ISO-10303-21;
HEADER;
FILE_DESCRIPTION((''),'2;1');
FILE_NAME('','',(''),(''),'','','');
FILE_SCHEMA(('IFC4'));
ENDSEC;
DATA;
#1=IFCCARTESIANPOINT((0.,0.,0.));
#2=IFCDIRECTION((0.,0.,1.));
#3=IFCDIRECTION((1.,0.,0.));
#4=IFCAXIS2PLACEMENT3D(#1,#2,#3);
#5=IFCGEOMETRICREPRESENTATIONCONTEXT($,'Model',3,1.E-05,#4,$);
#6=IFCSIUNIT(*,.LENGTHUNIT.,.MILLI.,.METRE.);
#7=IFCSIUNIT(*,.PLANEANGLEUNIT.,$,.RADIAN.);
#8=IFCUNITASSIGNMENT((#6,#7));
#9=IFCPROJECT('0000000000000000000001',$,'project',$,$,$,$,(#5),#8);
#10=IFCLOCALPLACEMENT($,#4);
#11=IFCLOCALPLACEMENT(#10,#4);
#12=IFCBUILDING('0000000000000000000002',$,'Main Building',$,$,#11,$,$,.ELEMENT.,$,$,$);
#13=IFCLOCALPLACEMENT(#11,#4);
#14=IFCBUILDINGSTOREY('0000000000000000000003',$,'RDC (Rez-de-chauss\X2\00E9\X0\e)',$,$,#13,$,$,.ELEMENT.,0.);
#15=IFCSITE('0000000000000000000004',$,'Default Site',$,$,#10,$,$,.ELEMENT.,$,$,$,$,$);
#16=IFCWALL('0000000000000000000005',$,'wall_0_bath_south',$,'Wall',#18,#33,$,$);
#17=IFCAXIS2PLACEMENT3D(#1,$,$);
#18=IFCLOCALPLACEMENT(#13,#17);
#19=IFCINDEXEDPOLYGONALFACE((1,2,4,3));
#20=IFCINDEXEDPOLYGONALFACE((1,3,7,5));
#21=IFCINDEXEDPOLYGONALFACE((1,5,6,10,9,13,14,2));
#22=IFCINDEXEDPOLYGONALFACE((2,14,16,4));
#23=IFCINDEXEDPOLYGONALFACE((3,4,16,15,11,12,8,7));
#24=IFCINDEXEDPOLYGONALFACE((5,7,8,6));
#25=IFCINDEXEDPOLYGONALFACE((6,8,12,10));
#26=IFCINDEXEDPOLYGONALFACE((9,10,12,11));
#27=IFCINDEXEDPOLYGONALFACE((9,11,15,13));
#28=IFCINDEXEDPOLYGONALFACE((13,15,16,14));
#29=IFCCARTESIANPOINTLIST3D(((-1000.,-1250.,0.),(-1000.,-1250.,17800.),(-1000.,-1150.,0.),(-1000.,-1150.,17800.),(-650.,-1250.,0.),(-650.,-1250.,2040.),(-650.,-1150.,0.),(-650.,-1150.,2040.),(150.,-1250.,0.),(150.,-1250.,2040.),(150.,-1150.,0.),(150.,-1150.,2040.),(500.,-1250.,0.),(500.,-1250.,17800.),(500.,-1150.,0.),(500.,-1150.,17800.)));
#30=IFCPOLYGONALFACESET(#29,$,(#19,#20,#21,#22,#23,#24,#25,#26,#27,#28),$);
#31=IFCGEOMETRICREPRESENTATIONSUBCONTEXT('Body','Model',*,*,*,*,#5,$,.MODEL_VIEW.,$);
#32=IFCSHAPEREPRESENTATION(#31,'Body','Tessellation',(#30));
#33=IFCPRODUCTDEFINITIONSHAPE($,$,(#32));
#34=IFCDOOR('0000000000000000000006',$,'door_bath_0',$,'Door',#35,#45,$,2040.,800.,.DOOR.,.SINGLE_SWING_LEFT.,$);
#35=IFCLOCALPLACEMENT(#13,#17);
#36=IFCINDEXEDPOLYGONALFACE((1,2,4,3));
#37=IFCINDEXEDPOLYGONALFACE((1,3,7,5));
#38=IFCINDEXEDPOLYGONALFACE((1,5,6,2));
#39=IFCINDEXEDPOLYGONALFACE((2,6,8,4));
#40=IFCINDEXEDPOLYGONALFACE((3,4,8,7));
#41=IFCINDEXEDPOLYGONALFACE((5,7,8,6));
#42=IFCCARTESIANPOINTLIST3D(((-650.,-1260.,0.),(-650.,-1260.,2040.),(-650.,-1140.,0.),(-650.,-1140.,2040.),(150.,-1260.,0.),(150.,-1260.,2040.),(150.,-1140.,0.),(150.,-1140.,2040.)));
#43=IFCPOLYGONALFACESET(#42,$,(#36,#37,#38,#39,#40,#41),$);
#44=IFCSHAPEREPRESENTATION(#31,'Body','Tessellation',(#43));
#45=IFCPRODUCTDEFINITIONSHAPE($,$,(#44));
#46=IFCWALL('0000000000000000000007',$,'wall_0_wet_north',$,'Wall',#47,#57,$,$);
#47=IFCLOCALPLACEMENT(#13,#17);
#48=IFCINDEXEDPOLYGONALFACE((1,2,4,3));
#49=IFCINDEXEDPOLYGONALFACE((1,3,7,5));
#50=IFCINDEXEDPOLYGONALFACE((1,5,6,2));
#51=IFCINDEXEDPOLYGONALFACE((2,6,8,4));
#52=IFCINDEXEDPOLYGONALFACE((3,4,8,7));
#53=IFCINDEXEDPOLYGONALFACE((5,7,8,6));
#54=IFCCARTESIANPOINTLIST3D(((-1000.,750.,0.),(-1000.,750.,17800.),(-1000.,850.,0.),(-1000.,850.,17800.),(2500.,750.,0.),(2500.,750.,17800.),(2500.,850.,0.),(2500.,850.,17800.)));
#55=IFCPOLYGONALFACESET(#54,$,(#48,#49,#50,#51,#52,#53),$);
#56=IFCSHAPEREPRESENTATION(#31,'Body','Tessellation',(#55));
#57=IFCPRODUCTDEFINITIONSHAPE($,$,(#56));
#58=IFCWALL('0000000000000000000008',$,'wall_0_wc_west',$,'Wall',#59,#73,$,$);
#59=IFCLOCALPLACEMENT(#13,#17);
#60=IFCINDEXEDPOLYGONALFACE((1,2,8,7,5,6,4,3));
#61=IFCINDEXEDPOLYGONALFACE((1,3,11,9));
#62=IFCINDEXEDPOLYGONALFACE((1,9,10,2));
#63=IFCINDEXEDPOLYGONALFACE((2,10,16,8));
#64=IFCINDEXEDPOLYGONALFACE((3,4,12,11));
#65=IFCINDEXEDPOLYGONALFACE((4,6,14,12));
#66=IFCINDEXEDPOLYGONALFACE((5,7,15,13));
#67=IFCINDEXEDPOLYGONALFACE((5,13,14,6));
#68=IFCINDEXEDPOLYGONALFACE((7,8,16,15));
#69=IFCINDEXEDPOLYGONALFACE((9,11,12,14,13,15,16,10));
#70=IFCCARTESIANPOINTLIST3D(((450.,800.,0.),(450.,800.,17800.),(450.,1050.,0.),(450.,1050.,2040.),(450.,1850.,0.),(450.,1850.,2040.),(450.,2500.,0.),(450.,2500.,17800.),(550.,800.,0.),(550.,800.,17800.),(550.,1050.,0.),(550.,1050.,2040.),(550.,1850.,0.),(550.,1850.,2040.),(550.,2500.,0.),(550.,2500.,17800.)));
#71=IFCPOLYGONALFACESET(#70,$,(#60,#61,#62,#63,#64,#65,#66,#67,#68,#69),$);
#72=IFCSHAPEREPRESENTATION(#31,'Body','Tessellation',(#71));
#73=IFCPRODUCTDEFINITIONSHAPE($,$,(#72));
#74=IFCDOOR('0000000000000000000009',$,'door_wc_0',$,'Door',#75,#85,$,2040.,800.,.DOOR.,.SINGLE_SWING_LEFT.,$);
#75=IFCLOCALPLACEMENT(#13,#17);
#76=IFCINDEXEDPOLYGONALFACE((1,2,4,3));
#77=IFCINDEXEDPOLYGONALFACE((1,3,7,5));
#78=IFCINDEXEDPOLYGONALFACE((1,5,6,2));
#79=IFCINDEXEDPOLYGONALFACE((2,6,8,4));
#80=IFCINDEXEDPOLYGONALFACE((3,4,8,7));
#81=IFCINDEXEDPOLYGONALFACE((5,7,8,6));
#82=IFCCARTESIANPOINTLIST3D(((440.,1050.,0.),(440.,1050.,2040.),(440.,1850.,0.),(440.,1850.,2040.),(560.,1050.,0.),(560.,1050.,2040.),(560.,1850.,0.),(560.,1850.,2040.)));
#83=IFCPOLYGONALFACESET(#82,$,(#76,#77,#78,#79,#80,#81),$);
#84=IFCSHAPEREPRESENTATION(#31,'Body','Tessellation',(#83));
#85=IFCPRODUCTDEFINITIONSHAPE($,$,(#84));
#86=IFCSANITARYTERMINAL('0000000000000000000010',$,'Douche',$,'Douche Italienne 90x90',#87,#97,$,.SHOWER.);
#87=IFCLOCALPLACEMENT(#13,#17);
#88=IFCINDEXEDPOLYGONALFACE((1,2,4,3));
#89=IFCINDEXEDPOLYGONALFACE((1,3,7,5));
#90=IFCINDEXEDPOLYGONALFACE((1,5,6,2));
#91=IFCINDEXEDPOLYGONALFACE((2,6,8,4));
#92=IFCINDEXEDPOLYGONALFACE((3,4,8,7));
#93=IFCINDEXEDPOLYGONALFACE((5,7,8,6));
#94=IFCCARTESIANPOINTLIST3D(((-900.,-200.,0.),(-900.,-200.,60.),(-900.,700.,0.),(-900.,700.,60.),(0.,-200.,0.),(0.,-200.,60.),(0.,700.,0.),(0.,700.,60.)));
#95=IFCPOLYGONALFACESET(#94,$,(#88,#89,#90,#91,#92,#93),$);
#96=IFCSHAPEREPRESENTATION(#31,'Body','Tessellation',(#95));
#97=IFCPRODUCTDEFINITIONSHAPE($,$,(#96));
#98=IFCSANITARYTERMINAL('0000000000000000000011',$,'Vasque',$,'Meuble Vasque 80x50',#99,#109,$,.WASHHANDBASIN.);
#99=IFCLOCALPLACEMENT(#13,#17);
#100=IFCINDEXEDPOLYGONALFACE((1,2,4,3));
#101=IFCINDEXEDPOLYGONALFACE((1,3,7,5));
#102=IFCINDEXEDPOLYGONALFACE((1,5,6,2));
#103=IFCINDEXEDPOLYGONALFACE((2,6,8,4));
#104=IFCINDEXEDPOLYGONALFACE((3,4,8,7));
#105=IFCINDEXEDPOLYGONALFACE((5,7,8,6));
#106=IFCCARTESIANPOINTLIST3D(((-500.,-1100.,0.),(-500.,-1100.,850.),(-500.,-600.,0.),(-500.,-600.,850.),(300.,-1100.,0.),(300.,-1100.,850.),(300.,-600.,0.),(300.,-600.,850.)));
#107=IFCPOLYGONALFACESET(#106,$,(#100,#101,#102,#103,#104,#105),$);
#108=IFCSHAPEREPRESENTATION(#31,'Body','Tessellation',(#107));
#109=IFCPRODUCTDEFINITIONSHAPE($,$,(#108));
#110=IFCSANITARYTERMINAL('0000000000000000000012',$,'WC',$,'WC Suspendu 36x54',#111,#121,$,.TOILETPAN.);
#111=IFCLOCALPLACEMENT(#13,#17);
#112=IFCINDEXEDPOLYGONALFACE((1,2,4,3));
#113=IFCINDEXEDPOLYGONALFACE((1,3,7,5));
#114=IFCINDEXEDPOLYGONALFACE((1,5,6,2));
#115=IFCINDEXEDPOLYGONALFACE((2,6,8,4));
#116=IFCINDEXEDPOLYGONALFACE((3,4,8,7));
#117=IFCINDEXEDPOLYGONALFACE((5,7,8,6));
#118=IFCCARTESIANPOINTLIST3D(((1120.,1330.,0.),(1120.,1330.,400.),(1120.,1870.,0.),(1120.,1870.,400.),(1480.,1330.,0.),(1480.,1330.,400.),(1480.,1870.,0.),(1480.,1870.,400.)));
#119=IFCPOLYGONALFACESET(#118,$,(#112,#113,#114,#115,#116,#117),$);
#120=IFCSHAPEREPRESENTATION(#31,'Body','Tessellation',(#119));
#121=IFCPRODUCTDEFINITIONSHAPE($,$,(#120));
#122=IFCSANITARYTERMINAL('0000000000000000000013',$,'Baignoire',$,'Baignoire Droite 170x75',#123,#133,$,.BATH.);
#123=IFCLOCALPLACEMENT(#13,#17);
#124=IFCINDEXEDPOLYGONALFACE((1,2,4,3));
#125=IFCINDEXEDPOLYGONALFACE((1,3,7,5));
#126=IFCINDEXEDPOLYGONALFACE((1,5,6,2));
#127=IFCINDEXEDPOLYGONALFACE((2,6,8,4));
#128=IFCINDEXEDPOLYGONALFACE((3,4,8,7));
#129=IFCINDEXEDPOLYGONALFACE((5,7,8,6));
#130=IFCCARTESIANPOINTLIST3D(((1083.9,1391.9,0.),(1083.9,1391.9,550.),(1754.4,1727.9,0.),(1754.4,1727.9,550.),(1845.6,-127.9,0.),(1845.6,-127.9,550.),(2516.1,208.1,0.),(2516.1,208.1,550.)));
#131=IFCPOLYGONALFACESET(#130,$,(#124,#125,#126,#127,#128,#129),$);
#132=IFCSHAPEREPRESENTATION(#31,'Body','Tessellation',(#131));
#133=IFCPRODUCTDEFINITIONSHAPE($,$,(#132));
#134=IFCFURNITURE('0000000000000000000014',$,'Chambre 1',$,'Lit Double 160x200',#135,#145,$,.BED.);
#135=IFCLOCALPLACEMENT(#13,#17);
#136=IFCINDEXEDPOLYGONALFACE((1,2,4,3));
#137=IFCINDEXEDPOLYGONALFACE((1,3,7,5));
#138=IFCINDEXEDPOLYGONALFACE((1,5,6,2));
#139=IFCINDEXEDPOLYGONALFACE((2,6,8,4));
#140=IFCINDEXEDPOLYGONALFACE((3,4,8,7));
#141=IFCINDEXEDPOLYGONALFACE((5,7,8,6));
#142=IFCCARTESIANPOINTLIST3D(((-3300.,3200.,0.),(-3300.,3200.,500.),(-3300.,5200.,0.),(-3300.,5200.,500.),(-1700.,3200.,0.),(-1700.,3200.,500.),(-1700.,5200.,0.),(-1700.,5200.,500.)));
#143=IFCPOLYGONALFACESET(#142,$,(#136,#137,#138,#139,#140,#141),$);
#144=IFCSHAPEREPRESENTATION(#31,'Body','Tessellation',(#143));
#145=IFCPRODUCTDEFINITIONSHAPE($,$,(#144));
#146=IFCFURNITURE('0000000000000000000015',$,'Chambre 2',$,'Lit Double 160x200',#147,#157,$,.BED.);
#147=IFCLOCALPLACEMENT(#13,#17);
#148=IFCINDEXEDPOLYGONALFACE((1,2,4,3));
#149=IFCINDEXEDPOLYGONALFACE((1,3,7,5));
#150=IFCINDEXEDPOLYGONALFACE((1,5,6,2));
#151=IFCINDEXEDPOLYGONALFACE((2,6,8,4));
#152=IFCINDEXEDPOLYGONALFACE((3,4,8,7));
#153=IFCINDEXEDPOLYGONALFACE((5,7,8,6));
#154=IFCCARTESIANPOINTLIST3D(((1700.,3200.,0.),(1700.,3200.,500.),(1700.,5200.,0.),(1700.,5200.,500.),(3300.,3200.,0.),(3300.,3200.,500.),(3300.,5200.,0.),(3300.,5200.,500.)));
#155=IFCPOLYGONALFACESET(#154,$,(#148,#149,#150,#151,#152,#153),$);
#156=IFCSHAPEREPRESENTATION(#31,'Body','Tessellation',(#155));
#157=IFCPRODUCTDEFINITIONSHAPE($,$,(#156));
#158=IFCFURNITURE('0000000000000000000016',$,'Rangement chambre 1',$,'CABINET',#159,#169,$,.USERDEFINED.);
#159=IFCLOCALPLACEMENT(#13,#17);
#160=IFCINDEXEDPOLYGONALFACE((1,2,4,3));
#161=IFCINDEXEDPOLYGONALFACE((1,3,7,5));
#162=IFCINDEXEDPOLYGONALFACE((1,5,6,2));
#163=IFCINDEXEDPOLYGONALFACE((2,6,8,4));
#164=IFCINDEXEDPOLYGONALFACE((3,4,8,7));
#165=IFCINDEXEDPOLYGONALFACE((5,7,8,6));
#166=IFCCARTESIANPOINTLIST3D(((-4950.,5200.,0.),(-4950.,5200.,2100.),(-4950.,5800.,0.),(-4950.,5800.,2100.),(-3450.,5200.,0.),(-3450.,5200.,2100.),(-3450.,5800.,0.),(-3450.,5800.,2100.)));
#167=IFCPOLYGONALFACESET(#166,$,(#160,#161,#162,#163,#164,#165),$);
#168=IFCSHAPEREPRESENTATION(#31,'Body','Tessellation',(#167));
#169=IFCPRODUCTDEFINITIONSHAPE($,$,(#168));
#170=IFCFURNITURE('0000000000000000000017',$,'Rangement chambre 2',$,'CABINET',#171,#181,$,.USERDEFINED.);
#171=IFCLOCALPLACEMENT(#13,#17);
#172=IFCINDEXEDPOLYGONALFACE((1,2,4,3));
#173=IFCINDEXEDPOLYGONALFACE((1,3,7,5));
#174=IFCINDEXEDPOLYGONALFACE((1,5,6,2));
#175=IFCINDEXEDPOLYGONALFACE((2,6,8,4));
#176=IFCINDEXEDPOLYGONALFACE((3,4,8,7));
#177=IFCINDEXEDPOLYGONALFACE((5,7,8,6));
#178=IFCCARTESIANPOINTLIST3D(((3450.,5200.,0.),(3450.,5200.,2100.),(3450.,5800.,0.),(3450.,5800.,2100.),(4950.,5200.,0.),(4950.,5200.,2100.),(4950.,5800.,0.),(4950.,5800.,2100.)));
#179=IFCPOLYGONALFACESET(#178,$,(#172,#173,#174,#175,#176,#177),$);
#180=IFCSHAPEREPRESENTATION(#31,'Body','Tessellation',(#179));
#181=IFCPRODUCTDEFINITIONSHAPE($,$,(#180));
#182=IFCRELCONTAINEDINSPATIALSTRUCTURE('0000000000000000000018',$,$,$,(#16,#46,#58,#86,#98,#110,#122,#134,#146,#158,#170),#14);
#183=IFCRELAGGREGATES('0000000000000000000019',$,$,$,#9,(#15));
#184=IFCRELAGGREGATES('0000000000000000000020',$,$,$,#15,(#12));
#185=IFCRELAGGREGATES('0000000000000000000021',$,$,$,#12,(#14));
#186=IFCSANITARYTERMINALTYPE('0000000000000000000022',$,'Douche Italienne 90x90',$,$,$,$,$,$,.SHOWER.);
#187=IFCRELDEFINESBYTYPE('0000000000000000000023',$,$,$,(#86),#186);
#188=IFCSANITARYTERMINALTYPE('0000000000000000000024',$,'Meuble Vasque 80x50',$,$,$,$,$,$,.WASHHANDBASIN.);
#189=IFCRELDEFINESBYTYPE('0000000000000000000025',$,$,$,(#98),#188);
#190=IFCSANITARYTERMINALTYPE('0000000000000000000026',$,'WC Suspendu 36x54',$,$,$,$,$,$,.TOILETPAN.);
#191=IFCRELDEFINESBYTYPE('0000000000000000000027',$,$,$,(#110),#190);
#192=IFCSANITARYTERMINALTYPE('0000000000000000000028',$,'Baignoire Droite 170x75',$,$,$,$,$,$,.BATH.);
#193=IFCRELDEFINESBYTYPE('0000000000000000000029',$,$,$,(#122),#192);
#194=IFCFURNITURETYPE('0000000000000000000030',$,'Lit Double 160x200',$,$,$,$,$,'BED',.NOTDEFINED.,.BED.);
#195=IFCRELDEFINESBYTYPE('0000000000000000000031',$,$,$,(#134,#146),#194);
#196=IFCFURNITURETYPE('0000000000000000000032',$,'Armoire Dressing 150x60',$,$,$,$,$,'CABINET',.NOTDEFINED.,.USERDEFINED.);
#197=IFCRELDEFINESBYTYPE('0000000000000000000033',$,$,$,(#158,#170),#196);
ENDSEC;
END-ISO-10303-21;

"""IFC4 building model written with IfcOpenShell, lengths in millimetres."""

from ifc_helpers import new_model, si_unit, frame, origin_with_axes, place, context, subcontext, project, spatial, polyline, outline, extrude, type_object, element, fill, save


model = new_model("IFC4")

# Units and contexts
model_context = context("Model", 3, precision=1e-05, world=origin_with_axes())
body_context = subcontext(model_context, "Body", "Model", "MODEL_VIEW")
ifc_project = project(units=[si_unit("LENGTHUNIT", "METRE", prefix="MILLI"), si_unit("PLANEANGLEUNIT", "RADIAN")], contexts=[model_context])

# Site, building, storey
site_placement = place(None, origin_with_axes())
site = spatial("IfcSite", under=ifc_project, at=site_placement, Name="Default Site", CompositionType="ELEMENT")
building_placement = place(site_placement, origin_with_axes())
building = spatial("IfcBuilding", under=site, at=building_placement, Name="Main Building", CompositionType="ELEMENT")
storey_placement = place(building_placement, origin_with_axes())
storey = spatial("IfcBuildingStorey", under=building, at=storey_placement, Name="RDC (Rez-de-chaussée)", CompositionType="ELEMENT", Elevation=0.0)

# Wall, opening, door
wall_1_placement = place(storey_placement, frame((-1000.0, -1200.0, 0.0), z_axis=(0.0, 0.0, 1.0), x_axis=(1.0, 0.0, 0.0)))
wall_1 = element("IfcWall", 1, at=wall_1_placement, inside=storey, Name="wall_0_bath_south", ObjectType="Wall", context=body_context, shape_type="SweptSolid", body=[
    extrude(outline(polyline([(0.0, -50.0), (1500.0, -50.0), (1500.0, 50.0), (0.0, 50.0), (0.0, -50.0)])), origin_with_axes(), (0.0, 0.0, 1.0), 17800.0),
])
placement_1 = place(wall_1_placement, frame((350.0, 0.0, 0.0), z_axis=(0.0, 0.0, 1.0), x_axis=(1.0, 0.0, 0.0)))
opening_1 = element("IfcOpeningElement", 2, at=placement_1, cuts=wall_1, PredefinedType="OPENING", context=body_context, shape_type="SweptSolid", body=[
    extrude(outline(polyline([(0.0, -60.0), (800.0, -60.0), (800.0, 60.0), (0.0, 60.0), (0.0, -60.0)])), origin_with_axes(), (0.0, 0.0, 1.0), 2040.0),
])
door_1 = element("IfcDoor", 3, at=placement_1, Name="door_bath_0", ObjectType="Door", OperationType="SINGLE_SWING_LEFT", OverallHeight=2040.0, OverallWidth=800.0, PredefinedType="DOOR", context=body_context, shape_type="SweptSolid", body=[
    extrude(outline(polyline([(0.0, -60.0), (800.0, -60.0), (800.0, 60.0), (0.0, 60.0), (0.0, -60.0)])), origin_with_axes(), (0.0, 0.0, 1.0), 2040.0),
])
fill(opening_1, door_1)

# Wall
wall_2_placement = place(storey_placement, frame((-1000.0, 800.0, 0.0), z_axis=(0.0, 0.0, 1.0), x_axis=(1.0, 0.0, 0.0)))
element("IfcWall", 4, at=wall_2_placement, inside=storey, Name="wall_0_wet_north", ObjectType="Wall", context=body_context, shape_type="SweptSolid", body=[
    extrude(outline(polyline([(0.0, -50.0), (3500.0, -50.0), (3500.0, 50.0), (0.0, 50.0), (0.0, -50.0)])), origin_with_axes(), (0.0, 0.0, 1.0), 17800.0),
])

# Wall, opening, door
wall_3_placement = place(storey_placement, frame((500.0, 800.0, 0.0), z_axis=(0.0, 0.0, 1.0), x_axis=(0.0, 1.0, 0.0)))
wall_3 = element("IfcWall", 5, at=wall_3_placement, inside=storey, Name="wall_0_wc_west", ObjectType="Wall", context=body_context, shape_type="SweptSolid", body=[
    extrude(outline(polyline([(0.0, -50.0), (1700.0, -50.0), (1700.0, 50.0), (0.0, 50.0), (0.0, -50.0)])), origin_with_axes(), (0.0, 0.0, 1.0), 17800.0),
])
placement_2 = place(wall_3_placement, frame((250.0, 0.0, 0.0), z_axis=(0.0, 0.0, 1.0), x_axis=(1.0, 0.0, 0.0)))
opening_2 = element("IfcOpeningElement", 6, at=placement_2, cuts=wall_3, PredefinedType="OPENING", context=body_context, shape_type="SweptSolid", body=[
    extrude(outline(polyline([(0.0, -60.0), (800.0, -60.0), (800.0, 60.0), (0.0, 60.0), (0.0, -60.0)])), origin_with_axes(), (0.0, 0.0, 1.0), 2040.0),
])
door_2 = element("IfcDoor", 7, at=placement_2, Name="door_wc_0", ObjectType="Door", OperationType="SINGLE_SWING_LEFT", OverallHeight=2040.0, OverallWidth=800.0, PredefinedType="DOOR", context=body_context, shape_type="SweptSolid", body=[
    extrude(outline(polyline([(0.0, -60.0), (800.0, -60.0), (800.0, 60.0), (0.0, 60.0), (0.0, -60.0)])), origin_with_axes(), (0.0, 0.0, 1.0), 2040.0),
])
fill(opening_2, door_2)

# Sanitary terminals
sanitary_terminal_type_1 = type_object("IfcSanitaryTerminalType", Name="Douche Italienne 90x90", PredefinedType="SHOWER")
sanitary_terminal_1_placement = place(storey_placement, frame((-450.0, 250.0, 0.0), z_axis=(0.0, 0.0, 1.0), x_axis=(1.0, 0.0, 0.0)))
element("IfcSanitaryTerminal", 8, at=sanitary_terminal_1_placement, inside=storey, type_object=sanitary_terminal_type_1, Name="Douche", ObjectType="Douche Italienne 90x90", PredefinedType="SHOWER", context=body_context, shape_type="SweptSolid", body=[
    extrude(outline(polyline([(-450.0, -450.0), (450.0, -450.0), (450.0, 450.0), (-450.0, 450.0), (-450.0, -450.0)])), origin_with_axes(), (0.0, 0.0, 1.0), 60.0),
])
sanitary_terminal_type_2 = type_object("IfcSanitaryTerminalType", Name="Meuble Vasque 80x50", PredefinedType="WASHHANDBASIN")
sanitary_terminal_2_placement = place(storey_placement, frame((-100.0, -850.0, 0.0), z_axis=(0.0, 0.0, 1.0), x_axis=(1.0, 0.0, 0.0)))
element("IfcSanitaryTerminal", 9, at=sanitary_terminal_2_placement, inside=storey, type_object=sanitary_terminal_type_2, Name="Vasque", ObjectType="Meuble Vasque 80x50", PredefinedType="WASHHANDBASIN", context=body_context, shape_type="SweptSolid", body=[
    extrude(outline(polyline([(-400.0, -250.0), (400.0, -250.0), (400.0, 250.0), (-400.0, 250.0), (-400.0, -250.0)])), origin_with_axes(), (0.0, 0.0, 1.0), 850.0),
])
sanitary_terminal_type_3 = type_object("IfcSanitaryTerminalType", Name="WC Suspendu 36x54", PredefinedType="TOILETPAN")
sanitary_terminal_3_placement = place(storey_placement, frame((1300.0, 1600.0, 0.0), z_axis=(0.0, 0.0, 1.0), x_axis=(1.0, 0.0, 0.0)))
element("IfcSanitaryTerminal", 10, at=sanitary_terminal_3_placement, inside=storey, type_object=sanitary_terminal_type_3, Name="WC", ObjectType="WC Suspendu 36x54", PredefinedType="TOILETPAN", context=body_context, shape_type="SweptSolid", body=[
    extrude(outline(polyline([(-180.0, -270.0), (180.0, -270.0), (180.0, 270.0), (-180.0, 270.0), (-180.0, -270.0)])), origin_with_axes(), (0.0, 0.0, 1.0), 400.0),
])
sanitary_terminal_type_4 = type_object("IfcSanitaryTerminalType", Name="Baignoire Droite 170x75", PredefinedType="BATH")
sanitary_terminal_4_placement = place(storey_placement, frame((1800.0, 800.0, 0.0), z_axis=(0.0, 0.0, 1.0), x_axis=(-0.448074, 0.893997, 0.0)))
element("IfcSanitaryTerminal", 11, at=sanitary_terminal_4_placement, inside=storey, type_object=sanitary_terminal_type_4, Name="Baignoire", ObjectType="Baignoire Droite 170x75", PredefinedType="BATH", context=body_context, shape_type="SweptSolid", body=[
    extrude(outline(polyline([(-850.0, -375.0), (850.0, -375.0), (850.0, 375.0), (-850.0, 375.0), (-850.0, -375.0)])), origin_with_axes(), (0.0, 0.0, 1.0), 550.0),
])

# Furniture
furniture_type_1 = type_object("IfcFurnitureType", Name="Lit Double 160x200", ElementType="BED", AssemblyPlace="NOTDEFINED", PredefinedType="BED")
for number, where, z_axis, x_axis, name in (
    (12, (-2500.0, 4200.0, 0.0), (0.0, 0.0, 1.0), (1.0, 0.0, 0.0), "Chambre 1"),
    (13, (2500.0, 4200.0, 0.0), (0.0, 0.0, 1.0), (1.0, 0.0, 0.0), "Chambre 2"),
):
    element("IfcFurniture", number, at=place(storey_placement, frame(where, z_axis=z_axis, x_axis=x_axis)), inside=storey, type_object=furniture_type_1, Name=name, ObjectType="Lit Double 160x200", PredefinedType="BED", context=body_context, shape_type="SweptSolid", body=[
        extrude(outline(polyline([(-800.0, -1000.0), (800.0, -1000.0), (800.0, 1000.0), (-800.0, 1000.0), (-800.0, -1000.0)])), origin_with_axes(), (0.0, 0.0, 1.0), 500.0),
    ])
furniture_type_2 = type_object("IfcFurnitureType", Name="Armoire Dressing 150x60", ElementType="CABINET", AssemblyPlace="NOTDEFINED", PredefinedType="USERDEFINED")
for number, where, z_axis, x_axis, name in (
    (14, (-4200.0, 5500.0, 0.0), (0.0, 0.0, 1.0), (1.0, 0.0, 0.0), "Rangement chambre 1"),
    (15, (4200.0, 5500.0, 0.0), (0.0, 0.0, 1.0), (1.0, 0.0, 0.0), "Rangement chambre 2"),
):
    element("IfcFurniture", number, at=place(storey_placement, frame(where, z_axis=z_axis, x_axis=x_axis)), inside=storey, type_object=furniture_type_2, Name=name, ObjectType="CABINET", PredefinedType="USERDEFINED", context=body_context, shape_type="SweptSolid", body=[
        extrude(outline(polyline([(-750.0, -300.0), (750.0, -300.0), (750.0, 300.0), (-750.0, 300.0), (-750.0, -300.0)])), origin_with_axes(), (0.0, 0.0, 1.0), 2100.0),
    ])

save(model, "model.ifc")
